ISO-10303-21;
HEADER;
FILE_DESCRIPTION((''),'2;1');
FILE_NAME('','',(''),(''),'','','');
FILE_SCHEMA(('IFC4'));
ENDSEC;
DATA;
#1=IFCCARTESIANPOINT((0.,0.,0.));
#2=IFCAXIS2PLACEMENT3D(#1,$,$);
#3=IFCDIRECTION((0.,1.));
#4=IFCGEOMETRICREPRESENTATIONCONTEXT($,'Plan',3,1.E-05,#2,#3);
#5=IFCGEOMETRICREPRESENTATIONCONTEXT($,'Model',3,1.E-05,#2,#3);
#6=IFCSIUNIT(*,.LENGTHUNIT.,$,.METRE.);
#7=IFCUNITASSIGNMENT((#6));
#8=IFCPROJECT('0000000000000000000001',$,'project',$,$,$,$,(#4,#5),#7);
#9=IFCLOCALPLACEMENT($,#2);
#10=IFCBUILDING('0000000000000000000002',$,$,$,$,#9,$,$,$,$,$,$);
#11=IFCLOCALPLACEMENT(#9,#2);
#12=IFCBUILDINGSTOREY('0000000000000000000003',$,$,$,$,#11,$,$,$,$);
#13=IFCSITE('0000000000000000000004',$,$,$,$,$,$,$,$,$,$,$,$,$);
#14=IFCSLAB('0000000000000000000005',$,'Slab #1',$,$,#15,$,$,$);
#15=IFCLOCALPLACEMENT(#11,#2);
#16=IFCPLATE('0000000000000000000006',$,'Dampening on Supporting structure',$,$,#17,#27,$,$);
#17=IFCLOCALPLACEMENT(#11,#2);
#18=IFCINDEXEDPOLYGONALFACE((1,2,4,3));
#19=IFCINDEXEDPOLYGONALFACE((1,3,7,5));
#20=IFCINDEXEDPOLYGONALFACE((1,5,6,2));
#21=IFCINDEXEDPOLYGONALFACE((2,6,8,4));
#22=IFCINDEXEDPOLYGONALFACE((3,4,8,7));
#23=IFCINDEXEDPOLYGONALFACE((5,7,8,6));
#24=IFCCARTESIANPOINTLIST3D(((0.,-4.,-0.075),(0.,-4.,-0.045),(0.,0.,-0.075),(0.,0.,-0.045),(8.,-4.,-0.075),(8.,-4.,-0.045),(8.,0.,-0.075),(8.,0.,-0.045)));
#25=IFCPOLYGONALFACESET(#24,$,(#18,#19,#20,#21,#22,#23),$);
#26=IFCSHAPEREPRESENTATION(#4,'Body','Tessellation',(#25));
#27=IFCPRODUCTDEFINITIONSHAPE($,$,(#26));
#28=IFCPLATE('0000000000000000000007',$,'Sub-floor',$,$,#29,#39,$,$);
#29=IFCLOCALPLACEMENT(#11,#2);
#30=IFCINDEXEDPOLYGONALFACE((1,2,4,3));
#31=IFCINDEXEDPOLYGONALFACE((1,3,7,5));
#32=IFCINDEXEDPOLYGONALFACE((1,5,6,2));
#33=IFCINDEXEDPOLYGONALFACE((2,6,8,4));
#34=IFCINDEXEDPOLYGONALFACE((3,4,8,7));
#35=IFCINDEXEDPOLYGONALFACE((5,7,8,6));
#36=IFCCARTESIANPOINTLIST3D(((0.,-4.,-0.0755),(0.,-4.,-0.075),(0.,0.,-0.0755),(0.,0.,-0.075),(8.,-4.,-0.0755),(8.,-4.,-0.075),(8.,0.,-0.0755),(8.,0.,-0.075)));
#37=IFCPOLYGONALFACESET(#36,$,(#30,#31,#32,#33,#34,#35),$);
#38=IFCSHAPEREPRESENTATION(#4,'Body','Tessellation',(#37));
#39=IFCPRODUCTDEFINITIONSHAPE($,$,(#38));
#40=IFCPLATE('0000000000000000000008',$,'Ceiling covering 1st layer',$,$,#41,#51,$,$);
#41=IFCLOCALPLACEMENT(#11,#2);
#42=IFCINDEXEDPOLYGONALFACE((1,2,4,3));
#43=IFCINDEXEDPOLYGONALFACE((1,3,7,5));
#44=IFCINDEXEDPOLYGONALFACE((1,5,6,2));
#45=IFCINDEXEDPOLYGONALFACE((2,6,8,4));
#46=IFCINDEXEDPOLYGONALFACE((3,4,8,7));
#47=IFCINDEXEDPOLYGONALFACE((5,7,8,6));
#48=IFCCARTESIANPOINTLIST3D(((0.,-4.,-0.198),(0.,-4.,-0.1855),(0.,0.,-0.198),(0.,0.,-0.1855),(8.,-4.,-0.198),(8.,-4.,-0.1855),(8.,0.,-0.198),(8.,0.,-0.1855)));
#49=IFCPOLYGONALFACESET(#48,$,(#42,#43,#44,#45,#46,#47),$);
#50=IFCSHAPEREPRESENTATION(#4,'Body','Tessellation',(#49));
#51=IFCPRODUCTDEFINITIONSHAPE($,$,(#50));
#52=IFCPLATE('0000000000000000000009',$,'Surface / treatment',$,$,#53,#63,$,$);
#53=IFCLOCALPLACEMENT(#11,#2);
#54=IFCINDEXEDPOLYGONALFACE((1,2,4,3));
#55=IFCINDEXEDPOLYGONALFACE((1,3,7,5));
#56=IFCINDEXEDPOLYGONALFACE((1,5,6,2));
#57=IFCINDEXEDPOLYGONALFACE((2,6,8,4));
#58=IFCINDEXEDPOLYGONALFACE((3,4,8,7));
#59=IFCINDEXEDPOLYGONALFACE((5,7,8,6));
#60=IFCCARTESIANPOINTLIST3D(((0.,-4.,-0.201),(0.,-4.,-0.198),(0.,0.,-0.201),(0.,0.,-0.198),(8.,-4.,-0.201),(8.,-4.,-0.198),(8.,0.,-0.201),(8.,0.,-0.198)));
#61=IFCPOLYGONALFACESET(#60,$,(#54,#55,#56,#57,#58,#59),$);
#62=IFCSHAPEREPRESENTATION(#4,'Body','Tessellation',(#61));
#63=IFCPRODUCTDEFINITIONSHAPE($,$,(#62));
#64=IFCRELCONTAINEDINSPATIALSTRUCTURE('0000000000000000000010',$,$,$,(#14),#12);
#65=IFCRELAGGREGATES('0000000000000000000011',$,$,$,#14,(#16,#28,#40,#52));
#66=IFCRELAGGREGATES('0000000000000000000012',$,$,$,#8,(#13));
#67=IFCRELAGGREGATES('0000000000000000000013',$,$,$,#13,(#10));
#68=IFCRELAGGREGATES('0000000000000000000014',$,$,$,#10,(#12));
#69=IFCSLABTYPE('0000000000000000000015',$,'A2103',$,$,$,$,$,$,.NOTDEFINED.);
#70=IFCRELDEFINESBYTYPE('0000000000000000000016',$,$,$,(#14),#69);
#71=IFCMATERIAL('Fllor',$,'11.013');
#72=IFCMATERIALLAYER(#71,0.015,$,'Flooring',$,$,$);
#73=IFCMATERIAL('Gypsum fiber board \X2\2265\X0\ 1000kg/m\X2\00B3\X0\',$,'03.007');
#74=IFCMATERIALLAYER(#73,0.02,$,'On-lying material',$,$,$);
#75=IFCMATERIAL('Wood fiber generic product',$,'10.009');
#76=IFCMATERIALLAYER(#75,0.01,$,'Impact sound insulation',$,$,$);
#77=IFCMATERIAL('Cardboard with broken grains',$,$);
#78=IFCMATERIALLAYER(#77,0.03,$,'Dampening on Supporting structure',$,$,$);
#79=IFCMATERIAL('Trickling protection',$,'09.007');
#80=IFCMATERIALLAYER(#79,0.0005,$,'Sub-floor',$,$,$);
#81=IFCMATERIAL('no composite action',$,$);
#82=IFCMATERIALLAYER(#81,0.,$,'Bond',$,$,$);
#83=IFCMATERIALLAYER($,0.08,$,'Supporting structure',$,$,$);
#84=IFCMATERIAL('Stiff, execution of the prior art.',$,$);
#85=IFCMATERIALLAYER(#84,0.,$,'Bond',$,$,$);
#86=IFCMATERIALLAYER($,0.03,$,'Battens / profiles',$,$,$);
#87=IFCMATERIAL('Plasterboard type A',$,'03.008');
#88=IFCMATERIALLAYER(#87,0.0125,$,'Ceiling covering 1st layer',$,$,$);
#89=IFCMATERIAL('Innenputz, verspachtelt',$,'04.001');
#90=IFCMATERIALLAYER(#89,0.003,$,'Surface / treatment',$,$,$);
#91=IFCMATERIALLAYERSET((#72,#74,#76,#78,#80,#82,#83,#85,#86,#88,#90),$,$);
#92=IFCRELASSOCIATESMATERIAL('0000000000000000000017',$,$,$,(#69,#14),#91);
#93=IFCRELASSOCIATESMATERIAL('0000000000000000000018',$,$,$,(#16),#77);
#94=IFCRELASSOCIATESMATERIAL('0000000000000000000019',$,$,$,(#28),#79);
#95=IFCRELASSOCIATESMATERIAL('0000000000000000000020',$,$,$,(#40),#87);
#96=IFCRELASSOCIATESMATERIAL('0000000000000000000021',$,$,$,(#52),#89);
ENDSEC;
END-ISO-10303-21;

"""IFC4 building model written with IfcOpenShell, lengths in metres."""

from ifc_helpers import new_model, si_unit, direction, frame, frame_2d, origin, place, context, project, spatial, rectangle, extrude, material, layer, layer_set, type_object, element, aggregate, save


model = new_model("IFC4")

# Units and contexts
plan_context = context("Plan", 3, precision=1e-05, world=origin(), true_north=direction((0.0, 1.0)))
model_context = context("Model", 3, precision=1e-05, world=origin(), true_north=direction((0.0, 1.0)))
ifc_project = project(units=[si_unit("LENGTHUNIT", "METRE")], contexts=[plan_context, model_context])

# Site, building, storey
site = spatial("IfcSite", under=ifc_project)
building_placement = place(None, origin())
building = spatial("IfcBuilding", under=site, at=building_placement)
storey_placement = place(building_placement, origin())
storey = spatial("IfcBuildingStorey", under=building, at=storey_placement)

# Slab, plates
ifc_material_1 = material(Name="Fllor", Category="11.013")
ifc_layer_1 = layer(ifc_material_1, 0.015, Name="Flooring")
ifc_material_2 = material(Name="Gypsum fiber board ≥ 1000kg/m³", Category="03.007")
ifc_layer_2 = layer(ifc_material_2, 0.02, Name="On-lying material")
ifc_material_3 = material(Name="Wood fiber generic product", Category="10.009")
ifc_layer_3 = layer(ifc_material_3, 0.01, Name="Impact sound insulation")
ifc_material_4 = material(Name="Cardboard with broken grains")
ifc_layer_4 = layer(ifc_material_4, 0.03, Name="Dampening on Supporting structure")
ifc_material_5 = material(Name="Trickling protection", Category="09.007")
ifc_layer_5 = layer(ifc_material_5, 0.0005, Name="Sub-floor")
ifc_material_6 = material(Name="no composite action")
ifc_layer_6 = layer(ifc_material_6, 0.0, Name="Bond")
ifc_layer_7 = layer(None, 0.08, Name="Supporting structure")
ifc_material_7 = material(Name="Stiff, execution of the prior art.")
ifc_layer_8 = layer(ifc_material_7, 0.0, Name="Bond")
ifc_layer_9 = layer(None, 0.03, Name="Battens / profiles")
ifc_material_8 = material(Name="Plasterboard type A", Category="03.008")
ifc_layer_10 = layer(ifc_material_8, 0.0125, Name="Ceiling covering 1st layer")
ifc_material_9 = material(Name="Innenputz, verspachtelt", Category="04.001")
ifc_layer_11 = layer(ifc_material_9, 0.003, Name="Surface / treatment")
ifc_layer_set = layer_set([ifc_layer_1, ifc_layer_2, ifc_layer_3, ifc_layer_4, ifc_layer_5, ifc_layer_6, ifc_layer_7, ifc_layer_8, ifc_layer_9, ifc_layer_10, ifc_layer_11])
slab_type = type_object("IfcSlabType", Name="A2103", PredefinedType="NOTDEFINED", material=ifc_layer_set)
slab_placement = place(None, frame((0.0, 0.0, 0.0), z_axis=(0.0, 0.0, -1.0), x_axis=(1.0, 0.0, 0.0)))
slab = element("IfcSlab", 1, at=slab_placement, inside=storey, type_object=slab_type, material=ifc_layer_set, Name="Slab #1")
plate_1_placement = place(slab_placement, origin())
plate_1 = element("IfcPlate", 2, at=plate_1_placement, material=ifc_material_4, Name="Dampening on Supporting structure", context=plan_context, shape_type="SweptSolid", body=[
    extrude(rectangle(XDim=8.0, YDim=4.0, at=frame_2d((4.0, 2.0), x_axis=(1.0, 0.0))), frame((0.0, 0.0, 0.045), z_axis=(0.0, 0.0, 1.0), x_axis=(1.0, 0.0, 0.0)), (0.0, 0.0, 1.0), 0.03),
])
plate_2_placement = place(slab_placement, origin())
plate_2 = element("IfcPlate", 3, at=plate_2_placement, material=ifc_material_5, Name="Sub-floor", context=plan_context, shape_type="SweptSolid", body=[
    extrude(rectangle(XDim=8.0, YDim=4.0, at=frame_2d((4.0, 2.0), x_axis=(1.0, 0.0))), frame((0.0, 0.0, 0.075), z_axis=(0.0, 0.0, 1.0), x_axis=(1.0, 0.0, 0.0)), (0.0, 0.0, 1.0), 0.0005),
])
plate_3_placement = place(slab_placement, origin())
plate_3 = element("IfcPlate", 4, at=plate_3_placement, material=ifc_material_8, Name="Ceiling covering 1st layer", context=plan_context, shape_type="SweptSolid", body=[
    extrude(rectangle(XDim=8.0, YDim=4.0, at=frame_2d((4.0, 2.0), x_axis=(1.0, 0.0))), frame((0.0, 0.0, 0.1855), z_axis=(0.0, 0.0, 1.0), x_axis=(1.0, 0.0, 0.0)), (0.0, 0.0, 1.0), 0.0125),
])
plate_4_placement = place(slab_placement, origin())
plate_4 = element("IfcPlate", 5, at=plate_4_placement, material=ifc_material_9, Name="Surface / treatment", context=plan_context, shape_type="SweptSolid", body=[
    extrude(rectangle(XDim=8.0, YDim=4.0, at=frame_2d((4.0, 2.0), x_axis=(1.0, 0.0))), frame((0.0, 0.0, 0.198), z_axis=(0.0, 0.0, 1.0), x_axis=(1.0, 0.0, 0.0)), (0.0, 0.0, 1.0), 0.003),
])
aggregate(slab, [plate_1, plate_2, plate_3, plate_4])

save(model, "model.ifc")
